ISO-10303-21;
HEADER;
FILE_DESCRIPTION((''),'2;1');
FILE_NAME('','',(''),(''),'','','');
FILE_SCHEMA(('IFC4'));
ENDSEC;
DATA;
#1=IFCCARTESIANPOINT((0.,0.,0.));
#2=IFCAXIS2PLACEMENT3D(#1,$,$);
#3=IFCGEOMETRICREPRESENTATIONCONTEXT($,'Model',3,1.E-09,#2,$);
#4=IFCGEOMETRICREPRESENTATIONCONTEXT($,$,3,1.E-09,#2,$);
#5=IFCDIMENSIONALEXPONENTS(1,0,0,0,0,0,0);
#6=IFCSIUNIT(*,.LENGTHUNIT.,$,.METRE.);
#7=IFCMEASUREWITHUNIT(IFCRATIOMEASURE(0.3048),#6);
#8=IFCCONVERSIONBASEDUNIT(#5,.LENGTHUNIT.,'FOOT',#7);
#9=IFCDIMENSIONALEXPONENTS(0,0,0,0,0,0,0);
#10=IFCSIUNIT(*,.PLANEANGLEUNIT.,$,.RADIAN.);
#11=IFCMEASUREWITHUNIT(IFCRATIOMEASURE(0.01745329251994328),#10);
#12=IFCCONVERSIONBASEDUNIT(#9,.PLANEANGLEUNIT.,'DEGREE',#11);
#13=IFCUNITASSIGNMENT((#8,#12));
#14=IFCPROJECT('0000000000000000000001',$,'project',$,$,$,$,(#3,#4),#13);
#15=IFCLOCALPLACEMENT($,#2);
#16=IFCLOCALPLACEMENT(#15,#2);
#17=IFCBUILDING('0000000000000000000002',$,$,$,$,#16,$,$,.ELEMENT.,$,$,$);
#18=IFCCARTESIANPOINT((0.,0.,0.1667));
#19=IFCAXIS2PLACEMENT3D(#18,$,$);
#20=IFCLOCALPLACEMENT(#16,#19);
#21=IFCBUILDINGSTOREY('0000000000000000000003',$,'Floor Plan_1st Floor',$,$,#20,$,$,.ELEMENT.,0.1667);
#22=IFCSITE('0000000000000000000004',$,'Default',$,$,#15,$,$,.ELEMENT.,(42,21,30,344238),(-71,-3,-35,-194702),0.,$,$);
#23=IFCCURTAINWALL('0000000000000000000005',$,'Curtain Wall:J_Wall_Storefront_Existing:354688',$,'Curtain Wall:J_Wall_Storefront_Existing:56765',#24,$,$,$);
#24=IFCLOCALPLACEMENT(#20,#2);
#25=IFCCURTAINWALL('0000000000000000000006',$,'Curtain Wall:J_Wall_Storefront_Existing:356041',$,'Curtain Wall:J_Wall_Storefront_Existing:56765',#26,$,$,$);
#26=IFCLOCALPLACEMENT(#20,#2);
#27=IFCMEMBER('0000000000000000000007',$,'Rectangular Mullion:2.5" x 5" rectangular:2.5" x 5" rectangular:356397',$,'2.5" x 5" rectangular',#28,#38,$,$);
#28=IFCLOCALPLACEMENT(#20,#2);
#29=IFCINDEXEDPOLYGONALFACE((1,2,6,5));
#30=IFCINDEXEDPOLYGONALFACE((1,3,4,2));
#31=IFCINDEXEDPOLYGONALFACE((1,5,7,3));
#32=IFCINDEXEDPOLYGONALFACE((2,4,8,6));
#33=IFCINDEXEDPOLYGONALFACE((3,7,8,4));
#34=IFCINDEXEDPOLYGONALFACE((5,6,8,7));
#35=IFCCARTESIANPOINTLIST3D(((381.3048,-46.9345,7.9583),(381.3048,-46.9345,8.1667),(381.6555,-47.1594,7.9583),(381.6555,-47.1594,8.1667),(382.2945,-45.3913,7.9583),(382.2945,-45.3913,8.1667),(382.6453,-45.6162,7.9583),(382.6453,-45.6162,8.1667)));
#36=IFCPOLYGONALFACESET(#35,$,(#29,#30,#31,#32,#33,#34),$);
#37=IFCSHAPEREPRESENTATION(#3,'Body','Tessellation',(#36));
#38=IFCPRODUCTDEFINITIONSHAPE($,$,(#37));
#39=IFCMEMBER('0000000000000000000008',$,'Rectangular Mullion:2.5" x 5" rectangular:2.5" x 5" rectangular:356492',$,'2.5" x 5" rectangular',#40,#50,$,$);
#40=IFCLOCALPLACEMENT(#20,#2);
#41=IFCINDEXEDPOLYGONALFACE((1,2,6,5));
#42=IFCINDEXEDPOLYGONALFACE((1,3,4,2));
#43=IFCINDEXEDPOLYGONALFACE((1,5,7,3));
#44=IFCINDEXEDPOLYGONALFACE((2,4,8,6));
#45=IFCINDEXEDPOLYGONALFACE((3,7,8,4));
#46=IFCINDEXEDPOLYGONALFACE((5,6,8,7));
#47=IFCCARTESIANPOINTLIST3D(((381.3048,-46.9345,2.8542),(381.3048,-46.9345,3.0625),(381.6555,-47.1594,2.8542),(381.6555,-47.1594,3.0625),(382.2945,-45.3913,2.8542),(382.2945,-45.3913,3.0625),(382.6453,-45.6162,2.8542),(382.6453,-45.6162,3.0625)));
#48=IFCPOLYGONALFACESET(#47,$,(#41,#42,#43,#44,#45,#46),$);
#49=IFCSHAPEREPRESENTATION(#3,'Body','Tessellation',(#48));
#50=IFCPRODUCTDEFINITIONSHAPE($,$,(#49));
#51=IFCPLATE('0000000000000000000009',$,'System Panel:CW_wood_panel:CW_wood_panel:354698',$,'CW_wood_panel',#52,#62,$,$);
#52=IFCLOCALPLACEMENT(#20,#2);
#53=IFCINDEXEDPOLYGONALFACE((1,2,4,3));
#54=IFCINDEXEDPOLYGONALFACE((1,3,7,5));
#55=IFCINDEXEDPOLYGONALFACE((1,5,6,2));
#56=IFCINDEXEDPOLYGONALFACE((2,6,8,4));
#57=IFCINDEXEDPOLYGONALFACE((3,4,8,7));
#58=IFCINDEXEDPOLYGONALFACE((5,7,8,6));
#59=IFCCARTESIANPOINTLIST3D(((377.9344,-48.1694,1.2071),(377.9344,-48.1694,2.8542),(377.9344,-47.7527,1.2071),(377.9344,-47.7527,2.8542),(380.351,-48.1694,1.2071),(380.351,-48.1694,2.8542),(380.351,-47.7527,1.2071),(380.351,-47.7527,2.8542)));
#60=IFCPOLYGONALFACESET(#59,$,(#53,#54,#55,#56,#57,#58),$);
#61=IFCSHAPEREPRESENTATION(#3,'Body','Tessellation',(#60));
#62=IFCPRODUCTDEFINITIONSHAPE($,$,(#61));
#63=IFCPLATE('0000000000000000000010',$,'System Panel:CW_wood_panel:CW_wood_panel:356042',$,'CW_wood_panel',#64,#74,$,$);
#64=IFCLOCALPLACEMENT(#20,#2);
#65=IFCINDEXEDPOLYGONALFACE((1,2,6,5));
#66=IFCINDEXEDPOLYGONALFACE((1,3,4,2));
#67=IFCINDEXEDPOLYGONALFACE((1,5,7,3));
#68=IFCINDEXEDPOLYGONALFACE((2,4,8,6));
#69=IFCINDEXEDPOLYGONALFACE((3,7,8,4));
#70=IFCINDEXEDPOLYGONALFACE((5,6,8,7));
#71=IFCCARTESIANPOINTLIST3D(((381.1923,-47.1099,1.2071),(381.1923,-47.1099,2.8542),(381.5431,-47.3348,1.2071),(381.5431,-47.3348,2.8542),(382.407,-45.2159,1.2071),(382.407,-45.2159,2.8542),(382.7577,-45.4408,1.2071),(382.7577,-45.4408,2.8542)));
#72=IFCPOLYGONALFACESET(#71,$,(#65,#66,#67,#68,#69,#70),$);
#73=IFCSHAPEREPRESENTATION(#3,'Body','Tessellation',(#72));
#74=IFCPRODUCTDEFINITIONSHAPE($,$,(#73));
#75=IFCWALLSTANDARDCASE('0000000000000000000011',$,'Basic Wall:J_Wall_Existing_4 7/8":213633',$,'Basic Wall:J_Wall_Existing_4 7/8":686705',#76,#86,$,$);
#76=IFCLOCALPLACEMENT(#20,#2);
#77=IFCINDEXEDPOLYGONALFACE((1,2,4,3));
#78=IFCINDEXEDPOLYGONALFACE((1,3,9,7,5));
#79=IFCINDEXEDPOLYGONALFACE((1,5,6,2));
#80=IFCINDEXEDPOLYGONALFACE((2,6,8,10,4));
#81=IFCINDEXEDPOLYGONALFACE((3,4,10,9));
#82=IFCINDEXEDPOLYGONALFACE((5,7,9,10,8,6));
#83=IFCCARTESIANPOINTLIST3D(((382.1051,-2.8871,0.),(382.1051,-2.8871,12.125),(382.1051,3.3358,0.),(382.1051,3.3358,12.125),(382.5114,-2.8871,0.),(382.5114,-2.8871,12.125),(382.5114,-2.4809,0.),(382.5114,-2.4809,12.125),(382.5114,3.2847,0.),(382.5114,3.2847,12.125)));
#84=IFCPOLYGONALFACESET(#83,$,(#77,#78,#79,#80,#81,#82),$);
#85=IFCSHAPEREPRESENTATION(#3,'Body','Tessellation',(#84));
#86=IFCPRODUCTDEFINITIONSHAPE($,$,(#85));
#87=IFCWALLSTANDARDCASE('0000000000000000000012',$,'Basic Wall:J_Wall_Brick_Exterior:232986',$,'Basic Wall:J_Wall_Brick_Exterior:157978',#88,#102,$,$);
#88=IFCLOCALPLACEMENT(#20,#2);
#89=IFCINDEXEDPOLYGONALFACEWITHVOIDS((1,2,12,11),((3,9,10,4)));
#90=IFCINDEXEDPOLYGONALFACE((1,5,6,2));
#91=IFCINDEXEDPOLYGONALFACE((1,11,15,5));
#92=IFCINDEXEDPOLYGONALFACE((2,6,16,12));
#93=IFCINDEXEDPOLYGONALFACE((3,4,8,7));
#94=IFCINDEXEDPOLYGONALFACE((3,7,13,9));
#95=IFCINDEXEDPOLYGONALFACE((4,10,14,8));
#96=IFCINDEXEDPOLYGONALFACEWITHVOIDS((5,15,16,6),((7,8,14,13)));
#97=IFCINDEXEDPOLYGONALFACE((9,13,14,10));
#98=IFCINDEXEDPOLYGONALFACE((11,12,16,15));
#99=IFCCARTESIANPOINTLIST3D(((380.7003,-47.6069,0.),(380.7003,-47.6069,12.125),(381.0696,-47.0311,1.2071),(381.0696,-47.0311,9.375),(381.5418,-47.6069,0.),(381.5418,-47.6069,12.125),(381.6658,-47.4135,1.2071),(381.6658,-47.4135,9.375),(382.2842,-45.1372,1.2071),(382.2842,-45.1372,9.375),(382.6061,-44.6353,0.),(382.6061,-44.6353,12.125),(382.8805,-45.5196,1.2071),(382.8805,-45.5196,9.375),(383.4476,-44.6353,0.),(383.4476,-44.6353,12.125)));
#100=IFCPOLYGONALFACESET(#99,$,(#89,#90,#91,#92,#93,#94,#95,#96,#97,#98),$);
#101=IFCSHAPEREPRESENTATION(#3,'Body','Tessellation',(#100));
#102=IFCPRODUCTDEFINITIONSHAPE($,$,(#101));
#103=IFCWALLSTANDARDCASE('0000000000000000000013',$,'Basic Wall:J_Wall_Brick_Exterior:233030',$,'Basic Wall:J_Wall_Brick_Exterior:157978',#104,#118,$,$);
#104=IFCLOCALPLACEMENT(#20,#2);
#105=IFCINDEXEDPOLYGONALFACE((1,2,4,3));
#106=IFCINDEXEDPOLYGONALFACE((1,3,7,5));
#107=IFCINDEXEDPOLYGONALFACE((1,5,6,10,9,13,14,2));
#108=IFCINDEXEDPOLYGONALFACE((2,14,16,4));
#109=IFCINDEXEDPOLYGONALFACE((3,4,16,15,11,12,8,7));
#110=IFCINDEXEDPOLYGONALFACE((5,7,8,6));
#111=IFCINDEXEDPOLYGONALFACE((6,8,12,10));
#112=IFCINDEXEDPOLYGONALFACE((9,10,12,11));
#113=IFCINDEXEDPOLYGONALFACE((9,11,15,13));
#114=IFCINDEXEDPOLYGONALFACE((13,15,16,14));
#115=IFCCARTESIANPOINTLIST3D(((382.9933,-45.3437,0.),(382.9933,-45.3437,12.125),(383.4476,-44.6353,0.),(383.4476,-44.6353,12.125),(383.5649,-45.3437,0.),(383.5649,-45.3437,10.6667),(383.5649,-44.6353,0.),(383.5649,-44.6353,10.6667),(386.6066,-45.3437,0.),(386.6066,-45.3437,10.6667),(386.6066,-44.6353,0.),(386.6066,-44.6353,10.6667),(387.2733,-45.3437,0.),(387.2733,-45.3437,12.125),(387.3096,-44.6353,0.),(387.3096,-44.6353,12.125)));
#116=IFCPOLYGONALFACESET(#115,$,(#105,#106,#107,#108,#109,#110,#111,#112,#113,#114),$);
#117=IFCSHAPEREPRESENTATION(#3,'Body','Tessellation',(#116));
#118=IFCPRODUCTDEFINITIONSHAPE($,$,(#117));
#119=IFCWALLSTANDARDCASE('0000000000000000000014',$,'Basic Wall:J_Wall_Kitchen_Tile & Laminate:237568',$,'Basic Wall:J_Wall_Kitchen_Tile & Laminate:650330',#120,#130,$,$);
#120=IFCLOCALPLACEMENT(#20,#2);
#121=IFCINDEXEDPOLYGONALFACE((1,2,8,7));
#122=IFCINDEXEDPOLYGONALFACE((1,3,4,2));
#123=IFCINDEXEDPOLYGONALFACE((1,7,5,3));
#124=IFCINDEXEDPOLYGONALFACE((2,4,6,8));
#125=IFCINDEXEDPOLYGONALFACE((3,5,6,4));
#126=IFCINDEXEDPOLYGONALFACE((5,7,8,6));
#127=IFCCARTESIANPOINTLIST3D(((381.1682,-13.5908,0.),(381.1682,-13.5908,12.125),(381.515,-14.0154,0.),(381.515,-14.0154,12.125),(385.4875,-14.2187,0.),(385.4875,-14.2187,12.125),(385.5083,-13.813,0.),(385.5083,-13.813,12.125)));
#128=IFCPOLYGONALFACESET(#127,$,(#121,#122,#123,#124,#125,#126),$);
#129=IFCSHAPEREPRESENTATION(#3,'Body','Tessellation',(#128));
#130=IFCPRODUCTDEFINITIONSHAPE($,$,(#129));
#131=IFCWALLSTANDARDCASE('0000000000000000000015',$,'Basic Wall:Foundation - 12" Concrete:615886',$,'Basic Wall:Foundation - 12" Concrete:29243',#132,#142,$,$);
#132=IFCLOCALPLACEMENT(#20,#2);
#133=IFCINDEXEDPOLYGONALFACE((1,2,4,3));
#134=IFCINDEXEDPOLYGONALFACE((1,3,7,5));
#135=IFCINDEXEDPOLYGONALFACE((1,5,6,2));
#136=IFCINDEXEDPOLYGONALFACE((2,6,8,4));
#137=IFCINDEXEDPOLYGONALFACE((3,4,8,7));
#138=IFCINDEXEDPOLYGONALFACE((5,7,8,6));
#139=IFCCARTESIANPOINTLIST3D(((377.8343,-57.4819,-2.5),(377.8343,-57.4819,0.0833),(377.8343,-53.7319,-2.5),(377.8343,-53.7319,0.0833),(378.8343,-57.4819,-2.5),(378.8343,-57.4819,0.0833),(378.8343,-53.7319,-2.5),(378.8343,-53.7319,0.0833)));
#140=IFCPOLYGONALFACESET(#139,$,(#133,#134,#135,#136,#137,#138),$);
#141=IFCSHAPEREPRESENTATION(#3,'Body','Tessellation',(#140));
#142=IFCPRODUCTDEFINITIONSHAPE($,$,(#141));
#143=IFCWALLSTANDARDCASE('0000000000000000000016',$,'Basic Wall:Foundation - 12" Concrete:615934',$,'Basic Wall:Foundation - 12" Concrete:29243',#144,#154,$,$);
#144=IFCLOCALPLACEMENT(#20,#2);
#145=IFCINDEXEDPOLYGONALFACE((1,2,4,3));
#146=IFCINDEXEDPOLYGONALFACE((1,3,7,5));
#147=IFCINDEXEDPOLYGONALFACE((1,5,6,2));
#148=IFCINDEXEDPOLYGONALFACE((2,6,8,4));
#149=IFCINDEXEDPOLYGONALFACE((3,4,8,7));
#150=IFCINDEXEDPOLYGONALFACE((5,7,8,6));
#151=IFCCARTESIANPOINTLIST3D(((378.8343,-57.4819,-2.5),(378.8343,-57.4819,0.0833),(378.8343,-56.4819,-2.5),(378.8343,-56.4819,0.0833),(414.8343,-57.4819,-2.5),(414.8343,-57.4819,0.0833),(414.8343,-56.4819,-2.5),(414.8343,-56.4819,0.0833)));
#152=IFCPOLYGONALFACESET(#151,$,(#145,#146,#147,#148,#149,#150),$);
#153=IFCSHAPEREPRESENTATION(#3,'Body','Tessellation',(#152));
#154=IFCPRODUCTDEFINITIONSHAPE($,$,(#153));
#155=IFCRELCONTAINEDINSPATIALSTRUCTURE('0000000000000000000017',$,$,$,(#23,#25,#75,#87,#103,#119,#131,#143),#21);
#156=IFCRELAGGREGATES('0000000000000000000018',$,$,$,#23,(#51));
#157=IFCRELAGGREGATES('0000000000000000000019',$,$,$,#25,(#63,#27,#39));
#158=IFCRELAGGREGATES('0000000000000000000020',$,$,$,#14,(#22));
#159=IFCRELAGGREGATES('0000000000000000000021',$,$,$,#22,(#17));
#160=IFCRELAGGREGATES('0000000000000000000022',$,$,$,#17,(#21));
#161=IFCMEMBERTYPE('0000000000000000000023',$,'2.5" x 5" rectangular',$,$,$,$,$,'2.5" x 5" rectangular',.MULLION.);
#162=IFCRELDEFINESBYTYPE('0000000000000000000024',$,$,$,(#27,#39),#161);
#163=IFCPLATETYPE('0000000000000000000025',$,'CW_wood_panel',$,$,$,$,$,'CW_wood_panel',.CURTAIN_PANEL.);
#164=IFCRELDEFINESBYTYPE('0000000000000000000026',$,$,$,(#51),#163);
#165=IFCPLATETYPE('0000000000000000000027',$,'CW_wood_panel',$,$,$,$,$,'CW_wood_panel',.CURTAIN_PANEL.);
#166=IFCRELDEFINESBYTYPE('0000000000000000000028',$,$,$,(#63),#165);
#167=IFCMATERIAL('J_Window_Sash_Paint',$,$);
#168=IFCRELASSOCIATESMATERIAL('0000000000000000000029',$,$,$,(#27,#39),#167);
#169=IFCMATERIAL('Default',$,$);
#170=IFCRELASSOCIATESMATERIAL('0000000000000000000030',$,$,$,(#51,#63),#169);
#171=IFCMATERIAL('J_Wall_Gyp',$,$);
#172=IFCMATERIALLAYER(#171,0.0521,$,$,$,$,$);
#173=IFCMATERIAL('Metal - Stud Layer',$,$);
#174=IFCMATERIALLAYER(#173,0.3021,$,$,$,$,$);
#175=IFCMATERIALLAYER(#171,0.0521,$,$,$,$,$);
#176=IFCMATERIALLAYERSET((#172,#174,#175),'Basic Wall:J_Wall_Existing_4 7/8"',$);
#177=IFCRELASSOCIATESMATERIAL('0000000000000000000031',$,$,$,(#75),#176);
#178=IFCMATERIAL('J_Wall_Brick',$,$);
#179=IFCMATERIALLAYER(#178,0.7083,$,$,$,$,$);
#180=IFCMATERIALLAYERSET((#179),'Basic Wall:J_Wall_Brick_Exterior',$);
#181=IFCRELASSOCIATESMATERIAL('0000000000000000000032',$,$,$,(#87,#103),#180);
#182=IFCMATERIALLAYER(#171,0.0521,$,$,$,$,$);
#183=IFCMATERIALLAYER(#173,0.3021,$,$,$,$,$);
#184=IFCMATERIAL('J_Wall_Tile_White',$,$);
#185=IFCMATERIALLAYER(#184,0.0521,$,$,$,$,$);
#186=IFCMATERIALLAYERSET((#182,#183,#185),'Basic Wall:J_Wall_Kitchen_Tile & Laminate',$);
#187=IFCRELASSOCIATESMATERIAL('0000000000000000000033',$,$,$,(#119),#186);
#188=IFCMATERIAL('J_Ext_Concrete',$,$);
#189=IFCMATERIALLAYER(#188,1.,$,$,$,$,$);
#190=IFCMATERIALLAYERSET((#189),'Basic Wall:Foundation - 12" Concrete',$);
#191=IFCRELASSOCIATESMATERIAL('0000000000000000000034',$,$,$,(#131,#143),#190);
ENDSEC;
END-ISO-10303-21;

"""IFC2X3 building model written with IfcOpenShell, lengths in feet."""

from ifc_helpers import new_model, entity, si_unit, converted_unit, frame, frame_2d, origin, origin_2d_with_axis, place, context, project, spatial, polyline, rectangle, outline, extrude, source, transform, mapped, material, layer, layer_set, layer_usage, type_object, type_shapes, element, aggregate, save


model = new_model("IFC2X3")

# Units and contexts
model_context = context("Model", 3, precision=1e-09, world=origin())
context_of_model = context(None, 3, precision=1e-09, world=origin())
ifc_project = project(units=[converted_unit("LENGTHUNIT", "FOOT", entity("IfcRatioMeasure", 0.3048), si_unit("LENGTHUNIT", "METRE"), dimensions=[1, 0, 0, 0, 0, 0, 0]), converted_unit("PLANEANGLEUNIT", "DEGREE", entity("IfcRatioMeasure", 0.01745329251994328), si_unit("PLANEANGLEUNIT", "RADIAN"), dimensions=[0, 0, 0, 0, 0, 0, 0])], contexts=[model_context, context_of_model])

# Site, building, storey
site_placement = place(None, origin())
site = spatial("IfcSite", under=ifc_project, at=site_placement, Name="Default", CompositionType="ELEMENT", RefLatitude=(42, 21, 30, 344238), RefLongitude=(-71, -3, -35, -194702), RefElevation=0.0)
building_placement = place(site_placement, origin())
building = spatial("IfcBuilding", under=site, at=building_placement, CompositionType="ELEMENT")
storey_placement = place(building_placement, frame((0.0, 0.0, 0.1667)))
storey = spatial("IfcBuildingStorey", under=building, at=storey_placement, Name="Floor Plan_1st Floor", CompositionType="ELEMENT", Elevation=0.1667)

# Shared definitions
ifc_material_1 = material(Name="J_Window_Sash_Paint")

# Curtain walls
curtain_wall_1_placement = place(storey_placement, origin())
curtain_wall_1 = element("IfcCurtainWall", 1, at=curtain_wall_1_placement, inside=storey, Name="Curtain Wall:J_Wall_Storefront_Existing:354688", ObjectType="Curtain Wall:J_Wall_Storefront_Existing:56765")
curtain_wall_2_placement = place(storey_placement, origin())
curtain_wall_2 = element("IfcCurtainWall", 2, at=curtain_wall_2_placement, inside=storey, Name="Curtain Wall:J_Wall_Storefront_Existing:356041", ObjectType="Curtain Wall:J_Wall_Storefront_Existing:56765")

# Members
member_type_1 = type_object("IfcMemberType", Name="2.5\" x 5\" rectangular", ElementType="2.5\" x 5\" rectangular", PredefinedType="MULLION")
shared_shape_1 = source(origin(), model_context, "Body", "SweptSolid", [
    extrude(rectangle(XDim=0.2083, YDim=0.4167, at=origin_2d_with_axis()), frame((0.0, 0.0, -1.8333), z_axis=(0.0, 0.0, 1.0), x_axis=(-1.0, 0.0, 0.0)), (0.0, 0.0, 1.0), 1.8333),
])
type_shapes(member_type_1, [shared_shape_1])
member_1_placement = place(storey_placement, frame((382.4699, -45.5037, 8.0625), z_axis=(0.539846, 0.841764, 0.0), x_axis=(0.0, 0.0, 1.0)))
member_1 = element("IfcMember", 3, at=member_1_placement, type_object=member_type_1, material=ifc_material_1, Name="Rectangular Mullion:2.5\" x 5\" rectangular:2.5\" x 5\" rectangular:356397", ObjectType="2.5\" x 5\" rectangular", context=model_context, shape_type="MappedRepresentation", body=[
    mapped(shared_shape_1, transform((0.0, 0.0, 0.0), scale=1.0)),
])
member_2_placement = place(storey_placement, frame((382.4699, -45.5037, 2.9583), z_axis=(0.539846, 0.841764, 0.0), x_axis=(0.0, 0.0, 1.0)))
member_2 = element("IfcMember", 4, at=member_2_placement, type_object=member_type_1, material=ifc_material_1, Name="Rectangular Mullion:2.5\" x 5\" rectangular:2.5\" x 5\" rectangular:356492", ObjectType="2.5\" x 5\" rectangular", context=model_context, shape_type="MappedRepresentation", body=[
    mapped(shared_shape_1, transform((0.0, 0.0, 0.0), scale=1.0)),
])

# Plates
ifc_material_2 = material(Name="Default")
plate_type_1 = type_object("IfcPlateType", Name="CW_wood_panel", ElementType="CW_wood_panel", PredefinedType="CURTAIN_PANEL")
shared_shape_2 = source(origin(), model_context, "Body", "SweptSolid", [
    extrude(rectangle(XDim=0.4167, YDim=2.4167, at=origin_2d_with_axis()), frame((0.0, 0.0, 0.0), z_axis=(0.0, 0.0, 1.0), x_axis=(0.0, 1.0, 0.0)), (0.0, 0.0, 1.0), 1.6471),
])
type_shapes(plate_type_1, [shared_shape_2])
plate_1_placement = place(storey_placement, frame((379.1427, -47.9611, 1.2071)))
plate_1 = element("IfcPlate", 5, at=plate_1_placement, type_object=plate_type_1, material=ifc_material_2, Name="System Panel:CW_wood_panel:CW_wood_panel:354698", ObjectType="CW_wood_panel", context=model_context, shape_type="MappedRepresentation", body=[
    mapped(shared_shape_2, transform((0.0, 0.0, 0.0), scale=1.0)),
])
aggregate(curtain_wall_1, [plate_1])
plate_type_2 = type_object("IfcPlateType", Name="CW_wood_panel", ElementType="CW_wood_panel", PredefinedType="CURTAIN_PANEL")
shared_shape_3 = source(origin(), model_context, "Body", "SweptSolid", [
    extrude(rectangle(XDim=0.4167, YDim=2.25, at=origin_2d_with_axis()), frame((0.0, 0.0, 0.0), z_axis=(0.0, 0.0, 1.0), x_axis=(0.0, 1.0, 0.0)), (0.0, 0.0, 1.0), 1.6471),
])
type_shapes(plate_type_2, [shared_shape_3])
plate_2_placement = place(storey_placement, frame((381.975, -46.2753, 1.2071), z_axis=(0.0, 0.0, 1.0), x_axis=(0.539846, 0.841764, 0.0)))
plate_2 = element("IfcPlate", 6, at=plate_2_placement, type_object=plate_type_2, material=ifc_material_2, Name="System Panel:CW_wood_panel:CW_wood_panel:356042", ObjectType="CW_wood_panel", context=model_context, shape_type="MappedRepresentation", body=[
    mapped(shared_shape_3, transform((0.0, 0.0, 0.0), scale=1.0)),
])
aggregate(curtain_wall_2, [plate_2, member_1, member_2])

# Wall
ifc_material_3 = material(Name="J_Wall_Gyp")
ifc_layer_1 = layer(ifc_material_3, 0.0521)
ifc_material_4 = material(Name="Metal - Stud Layer")
ifc_layer_2 = layer(ifc_material_4, 0.3021)
ifc_layer_3 = layer(ifc_material_3, 0.0521)
ifc_layer_set_1 = layer_set([ifc_layer_1, ifc_layer_2, ifc_layer_3], Name="Basic Wall:J_Wall_Existing_4 7/8\"")
ifc_layer_usage_1 = layer_usage(ifc_layer_set_1, "AXIS2", "NEGATIVE", 0.2031)
wall_1_placement = place(storey_placement, frame((382.3082, -2.8871, 0.0), z_axis=(0.0, 0.0, 1.0), x_axis=(0.0, 1.0, 0.0)))
element("IfcWallStandardCase", 7, at=wall_1_placement, inside=storey, material=ifc_layer_usage_1, Name="Basic Wall:J_Wall_Existing_4 7/8\":213633", ObjectType="Basic Wall:J_Wall_Existing_4 7/8\":686705", context=model_context, shape_type="SweptSolid", body=[
    extrude(outline(polyline([(6.1718, -0.2031), (6.2229, 0.2031), (0.0, 0.2031), (0.0, -0.2031), (0.4062, -0.2031), (6.1718, -0.2031)])), origin(), (0.0, 0.0, 1.0), 12.125),
])

# Walls, openings
ifc_material_5 = material(Name="J_Wall_Brick")
ifc_layer_4 = layer(ifc_material_5, 0.7083)
ifc_layer_set_2 = layer_set([ifc_layer_4], Name="Basic Wall:J_Wall_Brick_Exterior")
ifc_layer_usage_2 = layer_usage(ifc_layer_set_2, "AXIS2", "POSITIVE", -0.3542)
wall_2_placement = place(storey_placement, frame((383.1494, -44.4441, 0.0), z_axis=(0.0, 0.0, 1.0), x_axis=(-0.539846, -0.841764, 0.0)))
wall_2 = element("IfcWallStandardCase", 8, at=wall_2_placement, inside=storey, material=ifc_layer_usage_2, Name="Basic Wall:J_Wall_Brick_Exterior:232986", ObjectType="Basic Wall:J_Wall_Brick_Exterior:157978", context=model_context, shape_type="SweptSolid", body=[
    extrude(outline(polyline([(3.9844, -0.3542), (3.5302, 0.3542), (0.8415, 0.3542), (0.0, 0.3542), (0.4543, -0.3542), (3.9844, -0.3542)])), origin(), (0.0, 0.0, 1.0), 12.125),
])
opening_1_placement = place(wall_2_placement, origin())
element("IfcOpeningElement", 9, at=opening_1_placement, cuts=wall_2, ObjectType="Opening", context=model_context, shape_type="SweptSolid", body=[
    extrude(rectangle(XDim=8.1679, YDim=2.25, at=frame_2d((0.0, 0.0), x_axis=(0.0, 1.0))), frame((2.1754, -0.8542, 5.291), z_axis=(0.0, 1.0, 0.0), x_axis=(-1.0, 0.0, 0.0)), (0.0, 0.0, 1.0), 1.7083),
])
ifc_layer_usage_3 = layer_usage(ifc_layer_set_2, "AXIS2", "NEGATIVE", 0.3542)
wall_3_placement = place(storey_placement, frame((382.9933, -44.9895, 0.0)))
wall_3 = element("IfcWallStandardCase", 10, at=wall_3_placement, inside=storey, material=ifc_layer_usage_3, Name="Basic Wall:J_Wall_Brick_Exterior:233030", ObjectType="Basic Wall:J_Wall_Brick_Exterior:157978", context=model_context, shape_type="SweptSolid", body=[
    extrude(outline(polyline([(0.0, -0.3542), (4.28, -0.3542), (4.3163, 0.3542), (0.4543, 0.3542), (0.0, -0.3542)])), origin(), (0.0, 0.0, 1.0), 12.125),
])
opening_2_placement = place(wall_3_placement, origin())
element("IfcOpeningElement", 11, at=opening_2_placement, cuts=wall_3, ObjectType="Opening", context=model_context, shape_type="SweptSolid", body=[
    extrude(rectangle(XDim=10.6667, YDim=3.0417, at=origin_2d_with_axis()), frame((2.0925, -0.8542, 5.3333), z_axis=(0.0, 1.0, 0.0), x_axis=(0.0, 0.0, 1.0)), (0.0, 0.0, 1.0), 1.7083),
])

# Walls
ifc_layer_5 = layer(ifc_material_3, 0.0521)
ifc_layer_6 = layer(ifc_material_4, 0.3021)
ifc_material_6 = material(Name="J_Wall_Tile_White")
ifc_layer_7 = layer(ifc_material_6, 0.0521)
ifc_layer_set_3 = layer_set([ifc_layer_5, ifc_layer_6, ifc_layer_7], Name="Basic Wall:J_Wall_Kitchen_Tile & Laminate")
ifc_layer_usage_4 = layer_usage(ifc_layer_set_3, "AXIS2", "NEGATIVE", 0.2031)
wall_4_placement = place(storey_placement, frame((381.1578, -13.7937, 0.0), z_axis=(0.0, 0.0, 1.0), x_axis=(0.998692, -0.05113, 0.0)))
element("IfcWallStandardCase", 12, at=wall_4_placement, inside=storey, material=ifc_layer_usage_4, Name="Basic Wall:J_Wall_Kitchen_Tile & Laminate:237568", ObjectType="Basic Wall:J_Wall_Kitchen_Tile & Laminate:650330", context=model_context, shape_type="SweptSolid", body=[
    extrude(outline(polyline([(4.3457, -0.2031), (4.3457, 0.2031), (0.0, 0.2031), (0.3681, -0.2031), (4.3457, -0.2031)])), origin(), (0.0, 0.0, 1.0), 12.125),
])
ifc_material_7 = material(Name="J_Ext_Concrete")
ifc_layer_8 = layer(ifc_material_7, 1.0)
ifc_layer_set_4 = layer_set([ifc_layer_8], Name="Basic Wall:Foundation - 12\" Concrete")
ifc_layer_usage_5 = layer_usage(ifc_layer_set_4, "AXIS2", "NEGATIVE", 0.5)
wall_5_placement = place(storey_placement, frame((378.3343, -53.7319, -2.5), z_axis=(0.0, 0.0, 1.0), x_axis=(0.0, -1.0, 0.0)))
element("IfcWallStandardCase", 13, at=wall_5_placement, inside=storey, material=ifc_layer_usage_5, Name="Basic Wall:Foundation - 12\" Concrete:615886", ObjectType="Basic Wall:Foundation - 12\" Concrete:29243", context=model_context, shape_type="SweptSolid", body=[
    extrude(rectangle(XDim=3.75, YDim=1.0, at=frame_2d((1.875, 0.0), x_axis=(-1.0, 0.0))), origin(), (0.0, 0.0, 1.0), 2.5833),
])
ifc_layer_usage_6 = layer_usage(ifc_layer_set_4, "AXIS2", "NEGATIVE", 0.5)
wall_6_placement = place(storey_placement, frame((378.8343, -56.9819, -2.5)))
element("IfcWallStandardCase", 14, at=wall_6_placement, inside=storey, material=ifc_layer_usage_6, Name="Basic Wall:Foundation - 12\" Concrete:615934", ObjectType="Basic Wall:Foundation - 12\" Concrete:29243", context=model_context, shape_type="SweptSolid", body=[
    extrude(rectangle(XDim=36.0, YDim=1.0, at=frame_2d((18.0, 0.0), x_axis=(-1.0, 0.0))), origin(), (0.0, 0.0, 1.0), 2.5833),
])

save(model, "model.ifc")
